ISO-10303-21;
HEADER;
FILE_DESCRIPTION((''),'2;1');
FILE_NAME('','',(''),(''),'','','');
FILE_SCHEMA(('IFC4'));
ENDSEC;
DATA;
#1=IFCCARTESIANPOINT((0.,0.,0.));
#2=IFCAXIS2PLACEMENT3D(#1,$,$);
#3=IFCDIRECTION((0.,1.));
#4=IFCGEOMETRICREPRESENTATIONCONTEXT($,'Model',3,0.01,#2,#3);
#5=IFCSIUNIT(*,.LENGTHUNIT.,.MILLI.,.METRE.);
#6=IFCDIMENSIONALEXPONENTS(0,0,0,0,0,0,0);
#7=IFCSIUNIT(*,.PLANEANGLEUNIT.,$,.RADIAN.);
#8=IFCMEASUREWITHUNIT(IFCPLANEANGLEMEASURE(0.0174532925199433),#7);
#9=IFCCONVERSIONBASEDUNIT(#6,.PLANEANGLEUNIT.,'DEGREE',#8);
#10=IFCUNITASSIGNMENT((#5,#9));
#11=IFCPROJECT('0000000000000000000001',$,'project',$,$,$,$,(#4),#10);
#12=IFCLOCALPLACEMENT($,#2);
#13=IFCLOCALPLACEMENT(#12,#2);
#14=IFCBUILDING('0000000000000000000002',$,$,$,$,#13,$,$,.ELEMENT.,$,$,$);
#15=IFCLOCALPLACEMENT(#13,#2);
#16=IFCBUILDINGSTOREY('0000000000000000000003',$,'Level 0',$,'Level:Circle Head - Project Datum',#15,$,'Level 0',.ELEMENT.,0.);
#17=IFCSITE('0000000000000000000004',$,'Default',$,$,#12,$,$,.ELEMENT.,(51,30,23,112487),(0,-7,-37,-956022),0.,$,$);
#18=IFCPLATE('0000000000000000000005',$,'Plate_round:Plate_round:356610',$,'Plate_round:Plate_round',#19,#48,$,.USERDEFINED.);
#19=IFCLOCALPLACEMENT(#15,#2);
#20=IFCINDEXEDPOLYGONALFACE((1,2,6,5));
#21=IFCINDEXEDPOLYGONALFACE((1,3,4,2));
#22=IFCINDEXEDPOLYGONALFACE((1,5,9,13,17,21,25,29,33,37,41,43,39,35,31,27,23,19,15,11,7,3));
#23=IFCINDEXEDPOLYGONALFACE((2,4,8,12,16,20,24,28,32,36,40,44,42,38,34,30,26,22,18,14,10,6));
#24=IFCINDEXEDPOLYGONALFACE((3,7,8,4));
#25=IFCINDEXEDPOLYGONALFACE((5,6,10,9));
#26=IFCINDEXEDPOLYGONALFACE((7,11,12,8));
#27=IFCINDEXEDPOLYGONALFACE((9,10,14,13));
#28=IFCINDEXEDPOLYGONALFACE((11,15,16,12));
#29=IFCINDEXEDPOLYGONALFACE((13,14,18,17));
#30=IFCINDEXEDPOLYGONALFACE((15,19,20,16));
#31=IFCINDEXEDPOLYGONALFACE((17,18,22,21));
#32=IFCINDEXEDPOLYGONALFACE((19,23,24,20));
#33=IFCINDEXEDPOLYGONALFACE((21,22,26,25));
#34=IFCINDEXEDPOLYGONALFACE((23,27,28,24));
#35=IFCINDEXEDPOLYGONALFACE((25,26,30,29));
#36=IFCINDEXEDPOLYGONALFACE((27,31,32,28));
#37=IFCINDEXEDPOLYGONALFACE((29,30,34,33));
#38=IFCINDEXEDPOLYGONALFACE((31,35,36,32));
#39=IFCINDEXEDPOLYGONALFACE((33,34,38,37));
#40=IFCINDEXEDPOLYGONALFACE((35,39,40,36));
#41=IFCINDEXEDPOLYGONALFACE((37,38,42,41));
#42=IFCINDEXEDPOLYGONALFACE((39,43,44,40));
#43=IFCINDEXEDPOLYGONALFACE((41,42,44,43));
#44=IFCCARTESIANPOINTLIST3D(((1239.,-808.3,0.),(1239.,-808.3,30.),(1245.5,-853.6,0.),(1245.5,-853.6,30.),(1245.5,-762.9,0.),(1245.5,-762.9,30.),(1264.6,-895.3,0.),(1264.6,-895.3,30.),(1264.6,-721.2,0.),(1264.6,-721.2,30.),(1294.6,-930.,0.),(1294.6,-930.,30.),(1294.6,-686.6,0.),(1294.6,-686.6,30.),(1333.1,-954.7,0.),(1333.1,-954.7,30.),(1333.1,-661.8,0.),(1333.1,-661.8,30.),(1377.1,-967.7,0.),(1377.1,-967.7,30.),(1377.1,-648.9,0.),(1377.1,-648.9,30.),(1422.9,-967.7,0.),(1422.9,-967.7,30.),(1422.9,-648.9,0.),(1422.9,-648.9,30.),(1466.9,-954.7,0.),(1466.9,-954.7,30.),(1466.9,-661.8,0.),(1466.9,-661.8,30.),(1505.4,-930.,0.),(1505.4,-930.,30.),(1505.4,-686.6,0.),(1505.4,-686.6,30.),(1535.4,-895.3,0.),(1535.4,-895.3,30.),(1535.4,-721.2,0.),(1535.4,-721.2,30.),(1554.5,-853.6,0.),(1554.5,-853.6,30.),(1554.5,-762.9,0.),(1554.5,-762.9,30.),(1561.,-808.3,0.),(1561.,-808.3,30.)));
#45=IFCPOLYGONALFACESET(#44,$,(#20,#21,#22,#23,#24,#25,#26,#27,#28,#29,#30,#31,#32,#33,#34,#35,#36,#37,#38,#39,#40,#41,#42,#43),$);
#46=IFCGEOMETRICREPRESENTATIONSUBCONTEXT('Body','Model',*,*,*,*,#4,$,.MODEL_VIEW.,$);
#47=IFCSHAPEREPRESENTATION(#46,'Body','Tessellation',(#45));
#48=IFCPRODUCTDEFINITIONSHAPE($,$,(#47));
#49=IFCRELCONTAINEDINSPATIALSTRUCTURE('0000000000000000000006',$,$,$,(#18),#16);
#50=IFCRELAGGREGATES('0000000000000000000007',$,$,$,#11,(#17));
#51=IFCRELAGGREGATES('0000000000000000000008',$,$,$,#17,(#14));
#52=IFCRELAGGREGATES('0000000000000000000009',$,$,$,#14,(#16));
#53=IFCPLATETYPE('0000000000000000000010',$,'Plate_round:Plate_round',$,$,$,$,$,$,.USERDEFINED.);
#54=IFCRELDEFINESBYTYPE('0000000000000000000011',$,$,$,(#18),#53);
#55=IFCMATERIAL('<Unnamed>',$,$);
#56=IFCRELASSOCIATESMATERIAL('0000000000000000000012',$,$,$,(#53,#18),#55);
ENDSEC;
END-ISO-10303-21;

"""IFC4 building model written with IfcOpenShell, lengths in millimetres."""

from ifc_helpers import new_model, entity, si_unit, converted_unit, direction, frame, origin, place, context, subcontext, project, spatial, arc, indexed_curve, outline, extrude, source, transform, mapped, material, type_object, type_shapes, element, save


model = new_model("IFC4")

# Units and contexts
model_context = context("Model", 3, precision=0.01, world=origin(), true_north=direction((0.0, 1.0)))
body_context = subcontext(model_context, "Body", "Model", "MODEL_VIEW")
ifc_project = project(units=[si_unit("LENGTHUNIT", "METRE", prefix="MILLI"), converted_unit("PLANEANGLEUNIT", "DEGREE", entity("IfcPlaneAngleMeasure", 0.0174532925199433), si_unit("PLANEANGLEUNIT", "RADIAN"), dimensions=[0, 0, 0, 0, 0, 0, 0])], contexts=[model_context])

# Site, building, storey
site_placement = place(None, origin())
site = spatial("IfcSite", under=ifc_project, at=site_placement, Name="Default", CompositionType="ELEMENT", RefLatitude=(51, 30, 23, 112487), RefLongitude=(0, -7, -37, -956022), RefElevation=0.0)
building_placement = place(site_placement, origin())
building = spatial("IfcBuilding", under=site, at=building_placement, CompositionType="ELEMENT")
storey_placement = place(building_placement, origin())
storey = spatial("IfcBuildingStorey", under=building, at=storey_placement, Name="Level 0", ObjectType="Level:Circle Head - Project Datum", LongName="Level 0", CompositionType="ELEMENT", Elevation=0.0)

# Plate
ifc_material_1 = material(Name="<Unnamed>")
plate_type = type_object("IfcPlateType", Name="Plate_round:Plate_round", PredefinedType="USERDEFINED", material=ifc_material_1)
shared_shape = source(origin(), body_context, "Body", "SweptSolid", [
    extrude(outline(indexed_curve([(-161.0, 0.0), (0.0, -161.0), (161.0, 0.0), (0.0, 161.0)], segments=[arc(1, 2, 3), arc(3, 4, 1)], self_intersect=False)), origin(), (0.0, 0.0, 1.0), 30.0),
])
type_shapes(plate_type, [shared_shape])
plate_placement = place(storey_placement, frame((1400.0, -808.3, 0.0)))
element("IfcPlate", 1, at=plate_placement, inside=storey, type_object=plate_type, material=ifc_material_1, Name="Plate_round:Plate_round:356610", ObjectType="Plate_round:Plate_round", PredefinedType="USERDEFINED", context=body_context, shape_type="MappedRepresentation", body=[
    mapped(shared_shape, transform((0.0, 0.0, 0.0), scale=1.0)),
])

save(model, "model.ifc")
